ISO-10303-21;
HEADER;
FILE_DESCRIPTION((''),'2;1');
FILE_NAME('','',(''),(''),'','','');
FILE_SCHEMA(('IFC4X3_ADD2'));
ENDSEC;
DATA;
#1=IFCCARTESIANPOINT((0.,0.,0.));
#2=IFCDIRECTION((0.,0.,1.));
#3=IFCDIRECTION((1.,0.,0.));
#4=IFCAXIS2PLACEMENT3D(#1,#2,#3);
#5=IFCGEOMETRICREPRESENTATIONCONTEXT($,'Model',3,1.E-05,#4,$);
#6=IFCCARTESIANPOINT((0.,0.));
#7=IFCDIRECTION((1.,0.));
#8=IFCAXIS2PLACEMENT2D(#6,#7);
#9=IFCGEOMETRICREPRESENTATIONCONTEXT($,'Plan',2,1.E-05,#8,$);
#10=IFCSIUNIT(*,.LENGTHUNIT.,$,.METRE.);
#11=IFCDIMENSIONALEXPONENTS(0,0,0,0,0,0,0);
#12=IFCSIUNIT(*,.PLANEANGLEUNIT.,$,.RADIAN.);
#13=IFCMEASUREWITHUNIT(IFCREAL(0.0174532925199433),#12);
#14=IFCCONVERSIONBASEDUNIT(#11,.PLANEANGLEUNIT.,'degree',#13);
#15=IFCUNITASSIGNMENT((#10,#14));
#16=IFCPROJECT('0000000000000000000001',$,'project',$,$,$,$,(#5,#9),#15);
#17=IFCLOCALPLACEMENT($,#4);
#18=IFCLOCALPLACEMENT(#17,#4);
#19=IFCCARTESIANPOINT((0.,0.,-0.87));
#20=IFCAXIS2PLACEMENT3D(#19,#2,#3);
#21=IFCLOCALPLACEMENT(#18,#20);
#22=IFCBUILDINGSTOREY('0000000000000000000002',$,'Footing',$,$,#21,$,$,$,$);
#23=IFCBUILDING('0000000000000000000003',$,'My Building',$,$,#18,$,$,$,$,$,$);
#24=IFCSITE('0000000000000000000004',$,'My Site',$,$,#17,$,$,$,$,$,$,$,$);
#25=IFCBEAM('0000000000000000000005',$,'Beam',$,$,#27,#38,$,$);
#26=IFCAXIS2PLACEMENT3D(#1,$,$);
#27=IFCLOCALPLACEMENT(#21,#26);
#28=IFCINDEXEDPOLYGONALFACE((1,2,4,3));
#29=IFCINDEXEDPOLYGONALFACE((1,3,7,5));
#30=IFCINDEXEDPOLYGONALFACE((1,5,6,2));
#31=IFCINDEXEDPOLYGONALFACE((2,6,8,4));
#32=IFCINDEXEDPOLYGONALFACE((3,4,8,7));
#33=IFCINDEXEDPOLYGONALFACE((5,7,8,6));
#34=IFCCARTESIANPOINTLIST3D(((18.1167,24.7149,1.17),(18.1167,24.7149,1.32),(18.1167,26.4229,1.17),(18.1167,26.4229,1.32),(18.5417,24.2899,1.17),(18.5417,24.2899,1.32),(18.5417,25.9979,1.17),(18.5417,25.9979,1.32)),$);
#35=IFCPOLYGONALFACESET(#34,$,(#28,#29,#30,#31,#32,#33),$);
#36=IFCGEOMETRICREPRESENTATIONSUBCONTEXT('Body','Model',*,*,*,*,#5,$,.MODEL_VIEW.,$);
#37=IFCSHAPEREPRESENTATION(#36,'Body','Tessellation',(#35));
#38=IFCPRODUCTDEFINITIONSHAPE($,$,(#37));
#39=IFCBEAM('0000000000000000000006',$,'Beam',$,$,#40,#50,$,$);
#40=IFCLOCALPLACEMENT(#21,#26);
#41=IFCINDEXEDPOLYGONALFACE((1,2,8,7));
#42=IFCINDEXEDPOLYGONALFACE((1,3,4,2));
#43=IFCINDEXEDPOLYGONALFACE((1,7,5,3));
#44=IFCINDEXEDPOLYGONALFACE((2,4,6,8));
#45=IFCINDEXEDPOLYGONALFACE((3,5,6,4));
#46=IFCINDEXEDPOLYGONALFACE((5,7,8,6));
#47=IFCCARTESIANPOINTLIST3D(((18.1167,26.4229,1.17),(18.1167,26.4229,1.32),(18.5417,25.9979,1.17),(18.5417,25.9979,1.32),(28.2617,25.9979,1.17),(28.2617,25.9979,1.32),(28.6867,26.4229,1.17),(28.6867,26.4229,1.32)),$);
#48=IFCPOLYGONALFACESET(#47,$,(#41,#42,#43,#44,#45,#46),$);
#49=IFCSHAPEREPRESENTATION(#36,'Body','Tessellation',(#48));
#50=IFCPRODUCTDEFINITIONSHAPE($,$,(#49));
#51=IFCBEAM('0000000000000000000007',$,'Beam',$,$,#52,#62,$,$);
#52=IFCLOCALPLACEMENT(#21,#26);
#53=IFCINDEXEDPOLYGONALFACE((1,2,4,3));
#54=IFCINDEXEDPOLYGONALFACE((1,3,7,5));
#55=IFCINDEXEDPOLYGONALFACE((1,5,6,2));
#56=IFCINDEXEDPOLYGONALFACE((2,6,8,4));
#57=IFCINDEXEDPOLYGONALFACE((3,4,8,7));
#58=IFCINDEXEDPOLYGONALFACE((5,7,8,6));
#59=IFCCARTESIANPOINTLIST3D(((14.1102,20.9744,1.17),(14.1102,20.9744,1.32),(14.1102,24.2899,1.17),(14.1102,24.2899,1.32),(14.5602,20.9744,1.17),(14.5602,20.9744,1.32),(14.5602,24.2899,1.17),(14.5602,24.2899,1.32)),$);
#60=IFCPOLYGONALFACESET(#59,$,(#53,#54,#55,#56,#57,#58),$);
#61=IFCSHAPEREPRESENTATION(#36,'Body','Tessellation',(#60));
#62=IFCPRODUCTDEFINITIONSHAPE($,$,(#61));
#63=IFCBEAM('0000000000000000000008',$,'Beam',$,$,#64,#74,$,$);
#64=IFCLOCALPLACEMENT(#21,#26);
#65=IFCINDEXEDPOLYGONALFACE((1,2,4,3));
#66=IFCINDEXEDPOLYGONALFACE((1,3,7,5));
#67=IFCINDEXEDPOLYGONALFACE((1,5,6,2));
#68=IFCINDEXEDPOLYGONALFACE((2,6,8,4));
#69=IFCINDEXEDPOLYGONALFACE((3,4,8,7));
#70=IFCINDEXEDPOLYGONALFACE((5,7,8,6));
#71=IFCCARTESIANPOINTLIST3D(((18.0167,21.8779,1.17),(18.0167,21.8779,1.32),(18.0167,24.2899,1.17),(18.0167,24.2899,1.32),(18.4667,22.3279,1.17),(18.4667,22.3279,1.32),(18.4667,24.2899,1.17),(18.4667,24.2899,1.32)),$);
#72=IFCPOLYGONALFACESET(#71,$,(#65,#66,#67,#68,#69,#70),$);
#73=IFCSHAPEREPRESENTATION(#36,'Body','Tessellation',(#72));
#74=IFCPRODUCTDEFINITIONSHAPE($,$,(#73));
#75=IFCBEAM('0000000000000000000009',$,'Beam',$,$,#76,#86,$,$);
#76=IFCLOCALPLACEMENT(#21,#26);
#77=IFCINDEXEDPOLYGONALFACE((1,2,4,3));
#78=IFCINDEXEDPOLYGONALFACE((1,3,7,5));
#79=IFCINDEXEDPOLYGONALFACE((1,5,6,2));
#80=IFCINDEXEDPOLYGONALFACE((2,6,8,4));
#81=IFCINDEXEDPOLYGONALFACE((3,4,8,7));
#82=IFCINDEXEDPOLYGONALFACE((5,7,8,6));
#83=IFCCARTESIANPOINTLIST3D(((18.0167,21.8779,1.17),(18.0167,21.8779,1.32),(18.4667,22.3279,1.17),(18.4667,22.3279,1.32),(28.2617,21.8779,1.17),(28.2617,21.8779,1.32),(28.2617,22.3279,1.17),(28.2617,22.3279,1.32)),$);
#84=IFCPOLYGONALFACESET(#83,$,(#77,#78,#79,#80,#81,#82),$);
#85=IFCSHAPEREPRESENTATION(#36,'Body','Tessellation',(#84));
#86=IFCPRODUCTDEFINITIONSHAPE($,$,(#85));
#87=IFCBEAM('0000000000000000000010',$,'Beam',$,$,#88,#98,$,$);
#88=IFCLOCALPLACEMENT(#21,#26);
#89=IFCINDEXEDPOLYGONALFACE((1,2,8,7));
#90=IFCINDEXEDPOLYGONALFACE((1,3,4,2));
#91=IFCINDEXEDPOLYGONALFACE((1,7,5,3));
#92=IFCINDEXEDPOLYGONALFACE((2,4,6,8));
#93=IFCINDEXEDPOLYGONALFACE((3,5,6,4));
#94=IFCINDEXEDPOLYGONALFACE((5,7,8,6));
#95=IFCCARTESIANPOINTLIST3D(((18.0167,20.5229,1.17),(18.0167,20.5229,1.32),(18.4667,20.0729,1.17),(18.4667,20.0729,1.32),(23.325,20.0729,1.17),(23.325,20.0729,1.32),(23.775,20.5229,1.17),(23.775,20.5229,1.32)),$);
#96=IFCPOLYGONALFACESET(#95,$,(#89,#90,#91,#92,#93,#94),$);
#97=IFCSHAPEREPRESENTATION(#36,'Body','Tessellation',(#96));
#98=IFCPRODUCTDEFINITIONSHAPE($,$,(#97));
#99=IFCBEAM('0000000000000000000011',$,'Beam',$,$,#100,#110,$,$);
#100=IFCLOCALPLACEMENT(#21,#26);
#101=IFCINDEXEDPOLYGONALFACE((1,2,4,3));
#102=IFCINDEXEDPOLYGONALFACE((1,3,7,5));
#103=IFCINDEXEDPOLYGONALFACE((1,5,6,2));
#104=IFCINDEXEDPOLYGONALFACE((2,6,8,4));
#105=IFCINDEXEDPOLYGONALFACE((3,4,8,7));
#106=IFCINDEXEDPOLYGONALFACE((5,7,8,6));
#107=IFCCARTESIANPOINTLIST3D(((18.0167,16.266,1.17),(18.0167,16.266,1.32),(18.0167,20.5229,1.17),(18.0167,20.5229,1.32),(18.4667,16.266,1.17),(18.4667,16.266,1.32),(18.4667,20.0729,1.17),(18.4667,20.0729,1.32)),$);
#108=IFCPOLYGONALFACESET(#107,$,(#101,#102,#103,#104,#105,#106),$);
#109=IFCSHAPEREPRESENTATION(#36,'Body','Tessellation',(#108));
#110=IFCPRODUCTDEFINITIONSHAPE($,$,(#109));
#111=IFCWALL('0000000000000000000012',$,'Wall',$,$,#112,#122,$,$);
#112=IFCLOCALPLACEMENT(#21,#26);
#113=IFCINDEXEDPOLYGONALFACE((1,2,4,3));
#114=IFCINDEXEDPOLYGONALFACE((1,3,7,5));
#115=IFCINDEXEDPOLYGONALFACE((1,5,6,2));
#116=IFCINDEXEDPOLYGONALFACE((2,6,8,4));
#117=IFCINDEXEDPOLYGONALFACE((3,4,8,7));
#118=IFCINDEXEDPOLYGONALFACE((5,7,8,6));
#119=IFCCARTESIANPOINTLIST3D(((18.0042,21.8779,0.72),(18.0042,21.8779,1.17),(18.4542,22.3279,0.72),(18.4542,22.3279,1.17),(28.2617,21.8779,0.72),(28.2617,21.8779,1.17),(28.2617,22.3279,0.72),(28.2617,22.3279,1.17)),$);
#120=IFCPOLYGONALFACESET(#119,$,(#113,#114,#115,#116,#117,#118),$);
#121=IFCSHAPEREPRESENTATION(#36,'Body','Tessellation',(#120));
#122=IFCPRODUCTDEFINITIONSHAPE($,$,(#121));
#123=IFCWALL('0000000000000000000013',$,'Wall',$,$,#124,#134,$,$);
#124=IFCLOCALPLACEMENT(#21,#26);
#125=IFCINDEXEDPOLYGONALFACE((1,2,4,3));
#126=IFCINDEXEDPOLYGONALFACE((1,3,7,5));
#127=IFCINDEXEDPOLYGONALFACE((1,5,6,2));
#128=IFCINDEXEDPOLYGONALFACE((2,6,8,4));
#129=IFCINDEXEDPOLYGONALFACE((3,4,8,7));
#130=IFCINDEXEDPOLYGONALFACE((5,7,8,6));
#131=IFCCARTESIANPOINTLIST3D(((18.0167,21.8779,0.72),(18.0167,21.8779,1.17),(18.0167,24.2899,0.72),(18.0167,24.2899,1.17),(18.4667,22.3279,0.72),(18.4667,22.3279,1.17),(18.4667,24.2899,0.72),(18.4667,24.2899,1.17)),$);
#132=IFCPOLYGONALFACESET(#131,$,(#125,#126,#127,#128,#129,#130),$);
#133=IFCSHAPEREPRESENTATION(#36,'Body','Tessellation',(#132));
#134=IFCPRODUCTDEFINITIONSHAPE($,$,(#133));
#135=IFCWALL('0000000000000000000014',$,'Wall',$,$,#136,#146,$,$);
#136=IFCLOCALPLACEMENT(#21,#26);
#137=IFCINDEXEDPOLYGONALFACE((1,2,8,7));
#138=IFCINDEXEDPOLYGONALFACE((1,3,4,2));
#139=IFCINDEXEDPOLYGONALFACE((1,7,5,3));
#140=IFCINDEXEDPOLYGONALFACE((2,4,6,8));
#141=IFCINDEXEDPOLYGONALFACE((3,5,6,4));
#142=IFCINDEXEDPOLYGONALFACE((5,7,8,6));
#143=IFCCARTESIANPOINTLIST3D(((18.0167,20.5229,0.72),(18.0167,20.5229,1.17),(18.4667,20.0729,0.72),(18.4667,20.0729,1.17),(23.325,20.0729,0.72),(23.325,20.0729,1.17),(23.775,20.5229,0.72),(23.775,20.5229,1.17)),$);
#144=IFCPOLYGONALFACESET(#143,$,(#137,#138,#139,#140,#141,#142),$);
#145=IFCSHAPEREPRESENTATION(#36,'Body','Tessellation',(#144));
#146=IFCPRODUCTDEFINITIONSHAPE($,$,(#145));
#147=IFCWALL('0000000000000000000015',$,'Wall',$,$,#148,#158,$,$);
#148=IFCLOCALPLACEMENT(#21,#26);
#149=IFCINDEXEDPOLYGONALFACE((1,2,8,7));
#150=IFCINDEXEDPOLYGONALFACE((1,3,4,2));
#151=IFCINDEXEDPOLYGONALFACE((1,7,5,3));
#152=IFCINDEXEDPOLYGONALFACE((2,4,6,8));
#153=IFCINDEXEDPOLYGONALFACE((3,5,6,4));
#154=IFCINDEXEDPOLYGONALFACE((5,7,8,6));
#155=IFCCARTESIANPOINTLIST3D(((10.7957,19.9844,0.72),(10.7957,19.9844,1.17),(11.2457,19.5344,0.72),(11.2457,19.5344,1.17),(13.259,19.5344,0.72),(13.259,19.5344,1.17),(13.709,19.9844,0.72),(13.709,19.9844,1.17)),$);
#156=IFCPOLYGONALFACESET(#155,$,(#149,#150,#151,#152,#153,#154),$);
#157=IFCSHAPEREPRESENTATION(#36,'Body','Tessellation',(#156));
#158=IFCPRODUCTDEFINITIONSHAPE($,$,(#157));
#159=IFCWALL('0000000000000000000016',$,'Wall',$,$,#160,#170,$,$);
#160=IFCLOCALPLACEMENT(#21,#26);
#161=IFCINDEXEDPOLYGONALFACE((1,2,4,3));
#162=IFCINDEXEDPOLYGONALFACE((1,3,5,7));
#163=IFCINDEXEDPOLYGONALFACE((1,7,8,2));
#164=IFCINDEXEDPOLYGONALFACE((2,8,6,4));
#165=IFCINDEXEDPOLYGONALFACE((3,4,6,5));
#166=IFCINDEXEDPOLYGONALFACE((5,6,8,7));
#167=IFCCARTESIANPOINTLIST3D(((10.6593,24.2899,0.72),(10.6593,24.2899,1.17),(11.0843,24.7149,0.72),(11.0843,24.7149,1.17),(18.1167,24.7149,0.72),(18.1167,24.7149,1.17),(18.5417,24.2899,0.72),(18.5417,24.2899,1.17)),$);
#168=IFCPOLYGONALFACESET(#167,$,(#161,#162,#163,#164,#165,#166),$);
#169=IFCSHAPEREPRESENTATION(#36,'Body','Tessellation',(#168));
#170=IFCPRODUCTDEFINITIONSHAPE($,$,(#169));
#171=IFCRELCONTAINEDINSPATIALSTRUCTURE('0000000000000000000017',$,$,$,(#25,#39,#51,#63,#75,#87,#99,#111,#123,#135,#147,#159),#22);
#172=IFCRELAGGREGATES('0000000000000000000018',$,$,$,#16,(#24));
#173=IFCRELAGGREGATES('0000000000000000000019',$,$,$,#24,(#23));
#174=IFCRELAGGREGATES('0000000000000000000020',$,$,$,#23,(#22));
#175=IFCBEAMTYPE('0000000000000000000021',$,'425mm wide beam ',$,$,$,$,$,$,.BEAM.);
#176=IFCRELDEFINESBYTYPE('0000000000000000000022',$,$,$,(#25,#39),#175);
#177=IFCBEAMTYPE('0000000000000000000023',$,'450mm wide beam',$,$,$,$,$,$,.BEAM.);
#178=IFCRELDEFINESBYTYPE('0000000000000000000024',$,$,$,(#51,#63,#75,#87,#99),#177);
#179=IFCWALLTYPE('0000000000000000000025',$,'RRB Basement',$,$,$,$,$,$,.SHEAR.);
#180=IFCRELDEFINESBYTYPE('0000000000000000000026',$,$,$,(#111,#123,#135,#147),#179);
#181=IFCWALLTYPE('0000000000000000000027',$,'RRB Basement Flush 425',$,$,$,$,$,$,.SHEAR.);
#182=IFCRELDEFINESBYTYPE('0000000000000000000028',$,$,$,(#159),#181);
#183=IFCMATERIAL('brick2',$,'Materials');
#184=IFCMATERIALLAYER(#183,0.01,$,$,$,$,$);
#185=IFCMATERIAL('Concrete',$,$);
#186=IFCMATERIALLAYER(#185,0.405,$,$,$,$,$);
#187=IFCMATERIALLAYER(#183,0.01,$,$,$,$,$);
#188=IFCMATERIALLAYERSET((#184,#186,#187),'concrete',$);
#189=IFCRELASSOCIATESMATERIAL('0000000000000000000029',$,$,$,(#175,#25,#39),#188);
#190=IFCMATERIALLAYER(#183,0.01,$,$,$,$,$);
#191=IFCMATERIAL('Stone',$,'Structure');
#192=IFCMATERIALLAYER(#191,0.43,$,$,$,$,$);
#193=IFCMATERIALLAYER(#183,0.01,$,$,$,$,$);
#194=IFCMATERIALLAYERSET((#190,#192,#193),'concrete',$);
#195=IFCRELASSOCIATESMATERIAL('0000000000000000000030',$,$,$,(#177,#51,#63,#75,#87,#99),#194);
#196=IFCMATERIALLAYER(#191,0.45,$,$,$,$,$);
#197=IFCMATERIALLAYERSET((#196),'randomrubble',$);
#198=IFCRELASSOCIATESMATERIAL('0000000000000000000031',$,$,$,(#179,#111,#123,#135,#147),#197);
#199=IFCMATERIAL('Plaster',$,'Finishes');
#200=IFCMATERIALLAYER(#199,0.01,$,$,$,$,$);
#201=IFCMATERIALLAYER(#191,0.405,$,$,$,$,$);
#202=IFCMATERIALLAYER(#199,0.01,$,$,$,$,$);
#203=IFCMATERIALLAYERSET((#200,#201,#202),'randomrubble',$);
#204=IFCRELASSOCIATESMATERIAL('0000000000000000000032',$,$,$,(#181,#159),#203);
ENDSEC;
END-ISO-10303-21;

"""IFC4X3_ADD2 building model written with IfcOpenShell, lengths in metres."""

from ifc_helpers import new_model, entity, si_unit, converted_unit, frame, origin_with_axes, origin_2d_with_axis, place, context, subcontext, project, spatial, line, indexed_curve, outline, extrude, material, layer, layer_set, layer_usage, type_object, element, save


model = new_model("IFC4X3_ADD2")

# Units and contexts
model_context = context("Model", 3, precision=1e-05, world=origin_with_axes())
plan_context = context("Plan", 2, precision=1e-05, world=origin_2d_with_axis())
body_context = subcontext(model_context, "Body", "Model", "MODEL_VIEW")
ifc_project = project(units=[si_unit("LENGTHUNIT", "METRE"), converted_unit("PLANEANGLEUNIT", "degree", entity("IfcReal", 0.0174532925199433), si_unit("PLANEANGLEUNIT", "RADIAN"), dimensions=[0, 0, 0, 0, 0, 0, 0])], contexts=[model_context, plan_context])

# Site, building, storey
site_placement = place(None, origin_with_axes())
site = spatial("IfcSite", under=ifc_project, at=site_placement, Name="My Site")
building_placement = place(site_placement, origin_with_axes())
building = spatial("IfcBuilding", under=site, at=building_placement, Name="My Building")
storey_placement = place(building_placement, frame((0.0, 0.0, -0.87), z_axis=(0.0, 0.0, 1.0), x_axis=(1.0, 0.0, 0.0)))
storey = spatial("IfcBuildingStorey", under=building, at=storey_placement, Name="Footing")

# Beams
ifc_material_1 = material(Name="brick2", Category="Materials")
ifc_layer_1 = layer(ifc_material_1, 0.01)
ifc_material_2 = material(Name="Concrete")
ifc_layer_2 = layer(ifc_material_2, 0.405)
ifc_layer_3 = layer(ifc_material_1, 0.01)
ifc_layer_set_1 = layer_set([ifc_layer_1, ifc_layer_2, ifc_layer_3], Name="concrete")
ifc_layer_usage_1 = layer_usage(ifc_layer_set_1, "AXIS2", "POSITIVE", 0.0)
beam_type_1 = type_object("IfcBeamType", Name="425mm wide beam ", PredefinedType="BEAM", material=ifc_layer_set_1)
beam_1_placement = place(storey_placement, frame((18.1167, 25.9979, 1.17), z_axis=(0.0, 0.0, 1.0), x_axis=(0.0, -1.0, 0.0)))
element("IfcBeam", 1, at=beam_1_placement, inside=storey, type_object=beam_type_1, material=ifc_layer_usage_1, Name="Beam", context=body_context, shape_type="SweptSolid", body=[
    extrude(outline(indexed_curve([(-0.425, 0.0), (0.0, 0.425), (1.708, 0.425), (1.283, 0.0)], segments=[line(1, 2, 3, 4, 1)])), origin_with_axes(), (0.0, 0.0, 1.0), 0.15),
])
ifc_layer_usage_2 = layer_usage(ifc_layer_set_1, "AXIS2", "POSITIVE", 0.0)
beam_2_placement = place(storey_placement, frame((18.1167, 25.9979, 1.17), z_axis=(0.0, 0.0, 1.0), x_axis=(1.0, 0.0, 0.0)))
element("IfcBeam", 2, at=beam_2_placement, inside=storey, type_object=beam_type_1, material=ifc_layer_usage_2, Name="Beam", context=body_context, shape_type="SweptSolid", body=[
    extrude(outline(indexed_curve([(0.425, 0.0), (0.0, 0.425), (10.57, 0.425), (10.145, 0.0)], segments=[line(1, 2, 3, 4, 1)])), origin_with_axes(), (0.0, 0.0, 1.0), 0.15),
])
ifc_layer_4 = layer(ifc_material_1, 0.01)
ifc_material_3 = material(Name="Stone", Category="Structure")
ifc_layer_5 = layer(ifc_material_3, 0.43)
ifc_layer_6 = layer(ifc_material_1, 0.01)
ifc_layer_set_2 = layer_set([ifc_layer_4, ifc_layer_5, ifc_layer_6], Name="concrete")
ifc_layer_usage_3 = layer_usage(ifc_layer_set_2, "AXIS2", "POSITIVE", 0.0)
beam_type_2 = type_object("IfcBeamType", Name="450mm wide beam", PredefinedType="BEAM", material=ifc_layer_set_2)
beam_3_placement = place(storey_placement, frame((14.1102, 24.2899, 1.17), z_axis=(0.0, 0.0, 1.0), x_axis=(0.0, -1.0, 0.0)))
element("IfcBeam", 3, at=beam_3_placement, inside=storey, type_object=beam_type_2, material=ifc_layer_usage_3, Name="Beam", context=body_context, shape_type="SweptSolid", body=[
    extrude(outline(indexed_curve([(0.0, 0.0), (0.0, 0.45), (3.3155, 0.45), (3.3155, 0.0)], segments=[line(1, 2, 3, 4, 1)])), origin_with_axes(), (0.0, 0.0, 1.0), 0.15),
])
ifc_layer_usage_4 = layer_usage(ifc_layer_set_2, "AXIS2", "POSITIVE", 0.0)
beam_4_placement = place(storey_placement, frame((18.0167, 24.2899, 1.17), z_axis=(0.0, 0.0, 1.0), x_axis=(0.0, -1.0, 0.0)))
element("IfcBeam", 4, at=beam_4_placement, inside=storey, type_object=beam_type_2, material=ifc_layer_usage_4, Name="Beam", context=body_context, shape_type="SweptSolid", body=[
    extrude(outline(indexed_curve([(0.0, 0.0), (0.0, 0.45), (1.962, 0.45), (2.412, 0.0)], segments=[line(1, 2, 3, 4, 1)])), origin_with_axes(), (0.0, 0.0, 1.0), 0.15),
])
ifc_layer_usage_5 = layer_usage(ifc_layer_set_2, "AXIS2", "POSITIVE", 0.0)
beam_5_placement = place(storey_placement, frame((18.0167, 21.8779, 1.17), z_axis=(0.0, 0.0, 1.0), x_axis=(1.0, 0.0, 0.0)))
element("IfcBeam", 5, at=beam_5_placement, inside=storey, type_object=beam_type_2, material=ifc_layer_usage_5, Name="Beam", context=body_context, shape_type="SweptSolid", body=[
    extrude(outline(indexed_curve([(0.0, 0.0), (0.45, 0.45), (10.245, 0.45), (10.245, 0.0)], segments=[line(1, 2, 3, 4, 1)])), origin_with_axes(), (0.0, 0.0, 1.0), 0.15),
])
ifc_layer_usage_6 = layer_usage(ifc_layer_set_2, "AXIS2", "POSITIVE", 0.0)
beam_6_placement = place(storey_placement, frame((18.0167, 20.0729, 1.17), z_axis=(0.0, 0.0, 1.0), x_axis=(1.0, 0.0, 0.0)))
element("IfcBeam", 6, at=beam_6_placement, inside=storey, type_object=beam_type_2, material=ifc_layer_usage_6, Name="Beam", context=body_context, shape_type="SweptSolid", body=[
    extrude(outline(indexed_curve([(0.45, 0.0), (0.0, 0.45), (5.7583, 0.45), (5.3083, 0.0)], segments=[line(1, 2, 3, 4, 1)])), origin_with_axes(), (0.0, 0.0, 1.0), 0.15),
])
ifc_layer_usage_7 = layer_usage(ifc_layer_set_2, "AXIS2", "POSITIVE", 0.0)
beam_7_placement = place(storey_placement, frame((18.0167, 20.0729, 1.17), z_axis=(0.0, 0.0, 1.0), x_axis=(0.0, -1.0, 0.0)))
element("IfcBeam", 7, at=beam_7_placement, inside=storey, type_object=beam_type_2, material=ifc_layer_usage_7, Name="Beam", context=body_context, shape_type="SweptSolid", body=[
    extrude(outline(indexed_curve([(-0.45, 0.0), (0.0, 0.45), (3.8069, 0.45), (3.8069, 0.0)], segments=[line(1, 2, 3, 4, 1)])), origin_with_axes(), (0.0, 0.0, 1.0), 0.15),
])

# Walls
ifc_layer_7 = layer(ifc_material_3, 0.45)
ifc_layer_set_3 = layer_set([ifc_layer_7], Name="randomrubble")
ifc_layer_usage_8 = layer_usage(ifc_layer_set_3, "AXIS2", "POSITIVE", 0.0)
wall_type_1 = type_object("IfcWallType", Name="RRB Basement", PredefinedType="SHEAR", material=ifc_layer_set_3)
wall_1_placement = place(storey_placement, frame((18.4542, 21.8779, 0.72), z_axis=(0.0, 0.0, 1.0), x_axis=(1.0, -0.000001, 0.0)))
element("IfcWall", 8, at=wall_1_placement, inside=storey, type_object=wall_type_1, material=ifc_layer_usage_8, Name="Wall", context=body_context, shape_type="SweptSolid", body=[
    extrude(outline(indexed_curve([(-0.45, 0.0), (0.0, 0.45), (9.8075, 0.45), (9.8075, 0.0)], segments=[line(1, 2, 3, 4, 1)])), origin_with_axes(), (0.0, 0.0, 1.0), 0.45),
])
ifc_layer_usage_9 = layer_usage(ifc_layer_set_3, "AXIS2", "POSITIVE", 0.0)
wall_2_placement = place(storey_placement, frame((18.4667, 21.8779, 0.72), z_axis=(0.0, 0.0, 1.0), x_axis=(0.0, 1.0, 0.0)))
element("IfcWall", 9, at=wall_2_placement, inside=storey, type_object=wall_type_1, material=ifc_layer_usage_9, Name="Wall", context=body_context, shape_type="SweptSolid", body=[
    extrude(outline(indexed_curve([(0.45, 0.0), (0.0, 0.45), (2.412, 0.45), (2.412, 0.0)], segments=[line(1, 2, 3, 4, 1)])), origin_with_axes(), (0.0, 0.0, 1.0), 0.45),
])
ifc_layer_usage_10 = layer_usage(ifc_layer_set_3, "AXIS2", "POSITIVE", 0.0)
wall_3_placement = place(storey_placement, frame((18.4667, 20.0729, 0.72), z_axis=(0.0, 0.0, 1.0), x_axis=(1.0, -0.000001, 0.0)))
element("IfcWall", 10, at=wall_3_placement, inside=storey, type_object=wall_type_1, material=ifc_layer_usage_10, Name="Wall", context=body_context, shape_type="SweptSolid", body=[
    extrude(outline(indexed_curve([(0.0, 0.0), (-0.45, 0.45), (5.3083, 0.45), (4.8583, 0.0)], segments=[line(1, 2, 3, 4, 1)])), origin_with_axes(), (0.0, 0.0, 1.0), 0.45),
])
ifc_layer_usage_11 = layer_usage(ifc_layer_set_3, "AXIS2", "POSITIVE", 0.0)
wall_4_placement = place(storey_placement, frame((13.709, 19.9844, 0.72), z_axis=(0.0, 0.0, 1.0), x_axis=(-1.0, 0.000001, 0.0)))
element("IfcWall", 11, at=wall_4_placement, inside=storey, type_object=wall_type_1, material=ifc_layer_usage_11, Name="Wall", context=body_context, shape_type="SweptSolid", body=[
    extrude(outline(indexed_curve([(0.0, 0.0), (0.45, 0.45), (2.4633, 0.45), (2.9133, 0.0)], segments=[line(1, 2, 3, 4, 1)])), origin_with_axes(), (0.0, 0.0, 1.0), 0.45),
])
ifc_material_4 = material(Name="Plaster", Category="Finishes")
ifc_layer_8 = layer(ifc_material_4, 0.01)
ifc_layer_9 = layer(ifc_material_3, 0.405)
ifc_layer_10 = layer(ifc_material_4, 0.01)
ifc_layer_set_4 = layer_set([ifc_layer_8, ifc_layer_9, ifc_layer_10], Name="randomrubble")
ifc_layer_usage_12 = layer_usage(ifc_layer_set_4, "AXIS2", "POSITIVE", 0.0)
wall_type_2 = type_object("IfcWallType", Name="RRB Basement Flush 425", PredefinedType="SHEAR", material=ifc_layer_set_4)
wall_5_placement = place(storey_placement, frame((18.5417, 24.7149, 0.72), z_axis=(0.0, 0.0, 1.0), x_axis=(-1.0, 0.0, 0.0)))
element("IfcWall", 12, at=wall_5_placement, inside=storey, type_object=wall_type_2, material=ifc_layer_usage_12, Name="Wall", context=body_context, shape_type="SweptSolid", body=[
    extrude(outline(indexed_curve([(0.425, 0.0), (0.0, 0.425), (7.8824, 0.425), (7.4574, 0.0)], segments=[line(1, 2, 3, 4, 1)])), origin_with_axes(), (0.0, 0.0, 1.0), 0.45),
])

save(model, "model.ifc")
